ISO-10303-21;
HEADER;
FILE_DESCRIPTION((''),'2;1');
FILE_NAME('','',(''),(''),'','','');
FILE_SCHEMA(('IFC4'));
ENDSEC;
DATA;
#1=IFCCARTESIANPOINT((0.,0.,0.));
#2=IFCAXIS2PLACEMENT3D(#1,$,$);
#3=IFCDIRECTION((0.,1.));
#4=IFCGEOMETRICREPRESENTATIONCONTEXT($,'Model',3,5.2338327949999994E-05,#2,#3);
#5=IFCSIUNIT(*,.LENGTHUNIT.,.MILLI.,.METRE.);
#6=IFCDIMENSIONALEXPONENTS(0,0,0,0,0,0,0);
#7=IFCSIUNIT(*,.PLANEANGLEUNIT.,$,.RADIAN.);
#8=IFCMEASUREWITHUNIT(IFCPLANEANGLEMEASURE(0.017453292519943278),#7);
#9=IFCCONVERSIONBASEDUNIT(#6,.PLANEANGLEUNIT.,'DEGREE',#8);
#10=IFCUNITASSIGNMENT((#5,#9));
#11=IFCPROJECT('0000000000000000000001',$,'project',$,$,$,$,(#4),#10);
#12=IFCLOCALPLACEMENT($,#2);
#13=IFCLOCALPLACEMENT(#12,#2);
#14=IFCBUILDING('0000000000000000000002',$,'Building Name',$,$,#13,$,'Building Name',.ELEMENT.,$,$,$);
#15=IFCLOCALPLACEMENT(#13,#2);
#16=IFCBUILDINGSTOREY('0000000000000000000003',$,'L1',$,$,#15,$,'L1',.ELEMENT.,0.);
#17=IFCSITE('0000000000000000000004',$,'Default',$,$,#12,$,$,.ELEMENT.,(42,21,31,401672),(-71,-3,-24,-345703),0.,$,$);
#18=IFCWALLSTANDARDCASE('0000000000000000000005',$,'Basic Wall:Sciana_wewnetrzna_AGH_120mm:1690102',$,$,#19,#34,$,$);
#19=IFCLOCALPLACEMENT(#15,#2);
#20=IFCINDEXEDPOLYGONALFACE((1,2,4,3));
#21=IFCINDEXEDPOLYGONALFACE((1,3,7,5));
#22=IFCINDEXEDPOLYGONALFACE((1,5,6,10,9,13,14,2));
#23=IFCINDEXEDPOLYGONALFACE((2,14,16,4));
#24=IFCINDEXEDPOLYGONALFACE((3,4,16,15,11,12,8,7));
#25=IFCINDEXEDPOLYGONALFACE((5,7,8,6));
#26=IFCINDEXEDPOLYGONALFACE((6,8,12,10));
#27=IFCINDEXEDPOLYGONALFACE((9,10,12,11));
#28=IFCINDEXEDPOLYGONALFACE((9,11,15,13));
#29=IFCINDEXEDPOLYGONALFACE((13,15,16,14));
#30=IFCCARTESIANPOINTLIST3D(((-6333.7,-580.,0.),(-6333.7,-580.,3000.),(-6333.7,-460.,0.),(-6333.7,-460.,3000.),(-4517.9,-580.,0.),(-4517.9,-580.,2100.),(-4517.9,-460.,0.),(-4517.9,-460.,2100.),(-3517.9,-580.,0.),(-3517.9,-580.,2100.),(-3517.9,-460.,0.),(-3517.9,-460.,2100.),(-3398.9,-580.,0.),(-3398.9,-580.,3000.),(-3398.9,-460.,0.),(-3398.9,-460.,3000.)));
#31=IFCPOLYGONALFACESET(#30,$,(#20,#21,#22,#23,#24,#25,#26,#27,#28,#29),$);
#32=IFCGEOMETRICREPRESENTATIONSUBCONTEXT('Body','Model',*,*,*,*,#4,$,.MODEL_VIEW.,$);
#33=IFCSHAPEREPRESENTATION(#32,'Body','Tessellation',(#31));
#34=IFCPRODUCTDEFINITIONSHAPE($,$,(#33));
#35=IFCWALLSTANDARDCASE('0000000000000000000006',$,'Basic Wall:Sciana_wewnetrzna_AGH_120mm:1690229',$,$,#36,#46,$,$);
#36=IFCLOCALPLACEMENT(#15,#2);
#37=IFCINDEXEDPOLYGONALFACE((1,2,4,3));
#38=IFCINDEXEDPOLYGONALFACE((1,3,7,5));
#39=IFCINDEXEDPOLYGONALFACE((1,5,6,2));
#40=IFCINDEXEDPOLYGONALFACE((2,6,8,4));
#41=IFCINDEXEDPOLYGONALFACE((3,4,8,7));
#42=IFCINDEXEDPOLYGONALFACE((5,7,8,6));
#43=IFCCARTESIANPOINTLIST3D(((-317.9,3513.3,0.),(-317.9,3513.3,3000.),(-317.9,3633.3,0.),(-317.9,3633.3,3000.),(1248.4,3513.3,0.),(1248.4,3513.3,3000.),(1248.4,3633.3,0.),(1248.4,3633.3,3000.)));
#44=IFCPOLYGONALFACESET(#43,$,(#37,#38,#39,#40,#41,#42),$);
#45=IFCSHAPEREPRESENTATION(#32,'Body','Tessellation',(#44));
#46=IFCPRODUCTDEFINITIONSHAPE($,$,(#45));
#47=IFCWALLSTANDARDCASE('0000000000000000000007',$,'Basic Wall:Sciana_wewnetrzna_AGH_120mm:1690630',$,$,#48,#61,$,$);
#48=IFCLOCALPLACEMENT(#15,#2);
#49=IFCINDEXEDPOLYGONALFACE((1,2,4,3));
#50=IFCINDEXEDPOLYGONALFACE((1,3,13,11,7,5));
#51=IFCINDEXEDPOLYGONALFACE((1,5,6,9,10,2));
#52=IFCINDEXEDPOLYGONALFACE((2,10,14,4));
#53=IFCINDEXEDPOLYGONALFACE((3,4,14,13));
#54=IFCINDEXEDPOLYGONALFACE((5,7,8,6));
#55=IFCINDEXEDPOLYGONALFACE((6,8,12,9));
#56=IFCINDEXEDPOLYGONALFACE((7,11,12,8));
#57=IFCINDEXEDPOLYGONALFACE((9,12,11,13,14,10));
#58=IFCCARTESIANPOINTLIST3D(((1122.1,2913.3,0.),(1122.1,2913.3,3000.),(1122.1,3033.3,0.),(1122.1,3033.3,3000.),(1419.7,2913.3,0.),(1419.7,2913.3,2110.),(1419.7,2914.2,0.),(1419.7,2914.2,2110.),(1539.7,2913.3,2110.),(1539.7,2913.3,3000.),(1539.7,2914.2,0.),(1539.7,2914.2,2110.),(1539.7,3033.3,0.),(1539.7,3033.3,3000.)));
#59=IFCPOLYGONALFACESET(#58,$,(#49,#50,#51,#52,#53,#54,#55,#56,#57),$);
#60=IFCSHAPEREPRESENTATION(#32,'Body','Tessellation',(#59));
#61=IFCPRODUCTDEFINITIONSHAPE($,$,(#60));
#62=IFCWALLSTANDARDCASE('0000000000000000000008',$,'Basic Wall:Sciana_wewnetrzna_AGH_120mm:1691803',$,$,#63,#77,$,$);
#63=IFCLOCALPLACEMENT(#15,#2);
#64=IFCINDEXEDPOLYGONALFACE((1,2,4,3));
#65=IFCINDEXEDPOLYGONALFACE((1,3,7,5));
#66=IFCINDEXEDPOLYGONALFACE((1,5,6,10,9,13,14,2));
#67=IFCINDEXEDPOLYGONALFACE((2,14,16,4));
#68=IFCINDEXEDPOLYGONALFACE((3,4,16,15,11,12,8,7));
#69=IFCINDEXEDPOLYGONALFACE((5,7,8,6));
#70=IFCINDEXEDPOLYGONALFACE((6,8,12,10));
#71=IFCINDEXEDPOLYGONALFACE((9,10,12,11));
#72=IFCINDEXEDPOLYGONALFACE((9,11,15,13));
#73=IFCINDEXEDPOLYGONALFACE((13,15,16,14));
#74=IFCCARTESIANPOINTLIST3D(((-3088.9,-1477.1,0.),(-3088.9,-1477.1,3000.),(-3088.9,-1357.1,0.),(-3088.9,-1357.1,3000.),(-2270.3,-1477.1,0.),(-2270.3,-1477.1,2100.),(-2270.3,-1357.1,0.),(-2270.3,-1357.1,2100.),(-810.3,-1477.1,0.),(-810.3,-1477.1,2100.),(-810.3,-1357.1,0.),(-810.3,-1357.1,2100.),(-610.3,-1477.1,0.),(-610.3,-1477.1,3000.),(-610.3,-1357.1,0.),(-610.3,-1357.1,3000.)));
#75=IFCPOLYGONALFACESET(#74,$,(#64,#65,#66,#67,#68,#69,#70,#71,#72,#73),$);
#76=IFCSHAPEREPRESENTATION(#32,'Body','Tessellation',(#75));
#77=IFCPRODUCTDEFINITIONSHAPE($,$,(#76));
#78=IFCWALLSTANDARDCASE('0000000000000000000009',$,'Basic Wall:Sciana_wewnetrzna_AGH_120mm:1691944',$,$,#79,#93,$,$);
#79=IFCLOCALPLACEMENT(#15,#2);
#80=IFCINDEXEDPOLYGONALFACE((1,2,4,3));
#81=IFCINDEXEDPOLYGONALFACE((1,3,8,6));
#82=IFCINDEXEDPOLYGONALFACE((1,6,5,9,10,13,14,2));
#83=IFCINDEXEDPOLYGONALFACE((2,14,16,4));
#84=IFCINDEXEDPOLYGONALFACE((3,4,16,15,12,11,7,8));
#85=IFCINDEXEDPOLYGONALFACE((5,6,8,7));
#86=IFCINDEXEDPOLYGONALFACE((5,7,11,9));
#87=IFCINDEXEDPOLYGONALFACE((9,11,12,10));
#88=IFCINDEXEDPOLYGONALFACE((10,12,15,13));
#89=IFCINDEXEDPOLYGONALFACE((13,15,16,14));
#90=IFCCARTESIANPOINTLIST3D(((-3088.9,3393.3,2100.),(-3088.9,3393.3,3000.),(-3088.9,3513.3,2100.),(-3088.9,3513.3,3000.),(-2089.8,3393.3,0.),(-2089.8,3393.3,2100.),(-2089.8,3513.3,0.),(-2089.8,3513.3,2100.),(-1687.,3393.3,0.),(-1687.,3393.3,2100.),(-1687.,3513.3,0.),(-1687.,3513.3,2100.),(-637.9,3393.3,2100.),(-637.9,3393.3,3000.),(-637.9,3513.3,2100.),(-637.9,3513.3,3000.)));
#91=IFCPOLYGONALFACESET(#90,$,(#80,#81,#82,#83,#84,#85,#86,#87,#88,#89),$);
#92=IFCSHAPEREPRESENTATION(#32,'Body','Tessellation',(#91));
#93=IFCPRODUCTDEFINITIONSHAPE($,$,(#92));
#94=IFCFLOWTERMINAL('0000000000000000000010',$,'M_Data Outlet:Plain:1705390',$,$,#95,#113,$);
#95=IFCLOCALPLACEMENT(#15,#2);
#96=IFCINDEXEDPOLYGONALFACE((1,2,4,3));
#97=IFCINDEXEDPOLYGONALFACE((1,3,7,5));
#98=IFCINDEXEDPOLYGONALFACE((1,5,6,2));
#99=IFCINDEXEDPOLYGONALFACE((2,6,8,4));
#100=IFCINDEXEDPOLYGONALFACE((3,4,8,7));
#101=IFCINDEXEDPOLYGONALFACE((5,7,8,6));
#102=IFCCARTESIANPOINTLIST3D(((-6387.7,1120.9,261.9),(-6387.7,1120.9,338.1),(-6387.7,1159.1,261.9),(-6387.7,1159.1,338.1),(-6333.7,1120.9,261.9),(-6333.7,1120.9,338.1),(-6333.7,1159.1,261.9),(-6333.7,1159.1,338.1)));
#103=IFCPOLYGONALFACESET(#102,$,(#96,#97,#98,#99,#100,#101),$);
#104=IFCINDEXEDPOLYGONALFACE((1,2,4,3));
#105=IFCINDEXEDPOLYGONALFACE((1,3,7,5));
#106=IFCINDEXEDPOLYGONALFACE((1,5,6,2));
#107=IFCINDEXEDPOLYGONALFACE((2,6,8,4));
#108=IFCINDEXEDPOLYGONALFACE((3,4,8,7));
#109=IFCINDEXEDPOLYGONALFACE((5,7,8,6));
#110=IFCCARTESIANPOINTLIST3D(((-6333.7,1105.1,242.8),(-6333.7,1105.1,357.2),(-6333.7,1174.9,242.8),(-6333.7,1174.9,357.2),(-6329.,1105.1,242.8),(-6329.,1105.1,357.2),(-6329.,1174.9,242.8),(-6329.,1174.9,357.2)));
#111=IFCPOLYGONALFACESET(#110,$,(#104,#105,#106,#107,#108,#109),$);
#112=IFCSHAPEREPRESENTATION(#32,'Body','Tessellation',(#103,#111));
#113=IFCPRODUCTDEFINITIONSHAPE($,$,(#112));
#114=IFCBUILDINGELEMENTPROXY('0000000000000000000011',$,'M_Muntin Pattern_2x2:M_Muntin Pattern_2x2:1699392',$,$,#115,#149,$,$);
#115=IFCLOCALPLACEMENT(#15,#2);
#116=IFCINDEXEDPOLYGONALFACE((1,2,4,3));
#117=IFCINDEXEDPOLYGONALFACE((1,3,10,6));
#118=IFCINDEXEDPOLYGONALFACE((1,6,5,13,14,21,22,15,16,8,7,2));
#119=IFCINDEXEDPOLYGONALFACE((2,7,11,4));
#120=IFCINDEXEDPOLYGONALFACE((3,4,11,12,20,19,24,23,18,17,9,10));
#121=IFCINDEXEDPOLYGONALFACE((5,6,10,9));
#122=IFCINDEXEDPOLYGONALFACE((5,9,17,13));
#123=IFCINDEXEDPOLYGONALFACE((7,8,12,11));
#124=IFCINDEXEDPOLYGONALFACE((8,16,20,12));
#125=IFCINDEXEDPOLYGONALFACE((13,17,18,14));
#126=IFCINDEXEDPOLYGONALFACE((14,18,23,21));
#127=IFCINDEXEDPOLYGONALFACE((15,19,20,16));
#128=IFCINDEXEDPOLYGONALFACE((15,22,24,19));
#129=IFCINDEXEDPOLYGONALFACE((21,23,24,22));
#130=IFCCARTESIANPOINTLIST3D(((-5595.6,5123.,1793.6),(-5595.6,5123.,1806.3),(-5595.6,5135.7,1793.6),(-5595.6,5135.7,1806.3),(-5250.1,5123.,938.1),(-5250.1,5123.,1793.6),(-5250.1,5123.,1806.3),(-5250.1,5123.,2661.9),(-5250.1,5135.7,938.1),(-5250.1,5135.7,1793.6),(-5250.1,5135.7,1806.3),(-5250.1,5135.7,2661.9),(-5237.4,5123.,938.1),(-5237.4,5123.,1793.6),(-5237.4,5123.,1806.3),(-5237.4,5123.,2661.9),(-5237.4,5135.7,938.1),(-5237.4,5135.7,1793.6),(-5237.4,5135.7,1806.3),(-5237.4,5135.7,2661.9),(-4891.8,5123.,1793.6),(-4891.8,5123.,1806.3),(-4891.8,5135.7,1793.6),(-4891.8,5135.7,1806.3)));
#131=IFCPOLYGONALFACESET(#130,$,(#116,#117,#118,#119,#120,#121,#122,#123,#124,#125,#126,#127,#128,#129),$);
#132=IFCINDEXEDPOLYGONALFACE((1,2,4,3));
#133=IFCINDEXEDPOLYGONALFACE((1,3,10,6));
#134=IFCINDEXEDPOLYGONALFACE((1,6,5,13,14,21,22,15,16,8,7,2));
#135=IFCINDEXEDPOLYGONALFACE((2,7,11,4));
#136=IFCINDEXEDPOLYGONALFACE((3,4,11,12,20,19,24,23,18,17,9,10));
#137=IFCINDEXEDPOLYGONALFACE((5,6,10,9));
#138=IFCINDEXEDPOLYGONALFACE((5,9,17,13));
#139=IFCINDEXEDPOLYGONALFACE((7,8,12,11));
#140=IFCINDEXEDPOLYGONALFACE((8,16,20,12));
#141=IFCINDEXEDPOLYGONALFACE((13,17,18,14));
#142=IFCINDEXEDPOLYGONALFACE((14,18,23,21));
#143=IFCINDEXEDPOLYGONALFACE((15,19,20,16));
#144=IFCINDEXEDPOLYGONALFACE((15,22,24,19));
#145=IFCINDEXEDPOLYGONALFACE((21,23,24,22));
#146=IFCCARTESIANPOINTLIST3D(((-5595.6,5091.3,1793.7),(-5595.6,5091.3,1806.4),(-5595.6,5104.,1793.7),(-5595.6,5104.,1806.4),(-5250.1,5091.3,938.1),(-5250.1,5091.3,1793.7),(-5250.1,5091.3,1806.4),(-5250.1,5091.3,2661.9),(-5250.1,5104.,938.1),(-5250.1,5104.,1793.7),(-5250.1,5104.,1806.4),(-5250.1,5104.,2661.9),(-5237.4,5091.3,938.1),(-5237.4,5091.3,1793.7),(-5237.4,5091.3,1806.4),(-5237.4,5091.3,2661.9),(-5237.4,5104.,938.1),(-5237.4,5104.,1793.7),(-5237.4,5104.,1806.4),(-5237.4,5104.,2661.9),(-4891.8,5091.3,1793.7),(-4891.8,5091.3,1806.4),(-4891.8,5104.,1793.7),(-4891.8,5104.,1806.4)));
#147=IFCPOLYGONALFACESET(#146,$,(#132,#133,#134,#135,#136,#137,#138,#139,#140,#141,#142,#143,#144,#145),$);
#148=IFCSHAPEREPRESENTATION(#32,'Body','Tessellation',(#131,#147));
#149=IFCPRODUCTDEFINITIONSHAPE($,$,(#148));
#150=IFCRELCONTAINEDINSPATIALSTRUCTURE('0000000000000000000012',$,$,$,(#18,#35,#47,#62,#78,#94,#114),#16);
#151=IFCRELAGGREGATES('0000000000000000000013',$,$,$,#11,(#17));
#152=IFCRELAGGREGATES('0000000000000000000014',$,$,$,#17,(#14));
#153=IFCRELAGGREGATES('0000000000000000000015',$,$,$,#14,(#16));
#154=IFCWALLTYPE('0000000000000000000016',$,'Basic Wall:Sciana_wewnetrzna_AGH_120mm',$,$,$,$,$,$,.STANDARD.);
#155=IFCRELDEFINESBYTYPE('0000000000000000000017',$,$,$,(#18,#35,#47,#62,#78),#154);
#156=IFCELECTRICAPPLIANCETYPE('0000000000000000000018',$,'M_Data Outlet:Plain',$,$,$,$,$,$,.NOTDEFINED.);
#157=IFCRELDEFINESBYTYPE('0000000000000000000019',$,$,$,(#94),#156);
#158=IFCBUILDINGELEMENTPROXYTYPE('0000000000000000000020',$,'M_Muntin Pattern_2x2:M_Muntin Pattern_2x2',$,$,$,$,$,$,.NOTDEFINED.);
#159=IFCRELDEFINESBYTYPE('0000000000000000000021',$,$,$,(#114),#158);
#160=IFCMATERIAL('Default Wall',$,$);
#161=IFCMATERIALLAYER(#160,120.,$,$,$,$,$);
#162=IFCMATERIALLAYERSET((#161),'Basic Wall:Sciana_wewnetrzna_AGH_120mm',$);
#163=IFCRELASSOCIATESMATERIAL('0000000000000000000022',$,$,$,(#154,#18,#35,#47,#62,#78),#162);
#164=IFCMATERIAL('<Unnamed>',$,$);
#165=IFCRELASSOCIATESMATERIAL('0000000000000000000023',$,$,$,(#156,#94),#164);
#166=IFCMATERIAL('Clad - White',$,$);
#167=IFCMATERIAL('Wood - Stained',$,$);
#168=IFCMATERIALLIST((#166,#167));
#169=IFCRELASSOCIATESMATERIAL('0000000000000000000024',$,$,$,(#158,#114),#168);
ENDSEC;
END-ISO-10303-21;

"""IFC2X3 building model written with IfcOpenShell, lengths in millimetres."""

from ifc_helpers import new_model, entity, si_unit, converted_unit, direction, frame, frame_2d, origin, place, context, subcontext, project, spatial, polyline, rectangle, outline, extrude, source, transform, mapped, material, material_list, layer, layer_set, layer_usage, type_object, type_shapes, element, save


model = new_model("IFC2X3")

# Units and contexts
model_context = context("Model", 3, precision=5.2338327949999994e-05, world=origin(), true_north=direction((0.0, 1.0)))
body_context = subcontext(model_context, "Body", "Model", "MODEL_VIEW")
ifc_project = project(units=[si_unit("LENGTHUNIT", "METRE", prefix="MILLI"), converted_unit("PLANEANGLEUNIT", "DEGREE", entity("IfcPlaneAngleMeasure", 0.017453292519943278), si_unit("PLANEANGLEUNIT", "RADIAN"), dimensions=[0, 0, 0, 0, 0, 0, 0])], contexts=[model_context])

# Site, building, storey
site_placement = place(None, origin())
site = spatial("IfcSite", under=ifc_project, at=site_placement, Name="Default", CompositionType="ELEMENT", RefLatitude=(42, 21, 31, 401672), RefLongitude=(-71, -3, -24, -345703), RefElevation=0.0)
building_placement = place(site_placement, origin())
building = spatial("IfcBuilding", under=site, at=building_placement, Name="Building Name", LongName="Building Name", CompositionType="ELEMENT")
storey_placement = place(building_placement, origin())
storey = spatial("IfcBuildingStorey", under=building, at=storey_placement, Name="L1", LongName="L1", CompositionType="ELEMENT", Elevation=0.0)

# Shared definitions
ifc_material_1 = material(Name="Default Wall")

# Wall, opening
ifc_layer_1 = layer(ifc_material_1, 120.0)
ifc_layer_set_1 = layer_set([ifc_layer_1], Name="Basic Wall:Sciana_wewnetrzna_AGH_120mm")
ifc_layer_usage_1 = layer_usage(ifc_layer_set_1, "AXIS2", "NEGATIVE", 60.0)
wall_type_1 = type_object("IfcWallType", Name="Basic Wall:Sciana_wewnetrzna_AGH_120mm", PredefinedType="STANDARD", material=ifc_layer_set_1)
wall_1_placement = place(storey_placement, frame((-6333.7, -520.0, 0.0)))
wall_1 = element("IfcWallStandardCase", 1, at=wall_1_placement, inside=storey, type_object=wall_type_1, material=ifc_layer_usage_1, Name="Basic Wall:Sciana_wewnetrzna_AGH_120mm:1690102", context=body_context, shape_type="SweptSolid", body=[
    extrude(rectangle(XDim=2934.8, YDim=120.0, at=frame_2d((1467.4, 0.0), x_axis=(1.0, 0.0))), origin(), (0.0, 0.0, 1.0), 3000.0),
])
opening_1_placement = place(wall_1_placement, frame((1815.8, -60.0, 0.0)))
element("IfcOpeningElement", 2, at=opening_1_placement, cuts=wall_1, ObjectType="Opening", context=body_context, shape_type="SweptSolid", body=[
    extrude(rectangle(XDim=2100.0, YDim=1000.0, at=frame_2d((1050.0, 500.0), x_axis=(1.0, 0.0))), frame((0.0, 0.0, 0.0), z_axis=(0.0, 1.0, 0.0), x_axis=(0.0, 0.0, 1.0)), (0.0, 0.0, 1.0), 120.0),
])

# Wall
ifc_layer_usage_2 = layer_usage(ifc_layer_set_1, "AXIS2", "NEGATIVE", 60.0)
wall_2_placement = place(storey_placement, frame((-317.9, 3573.3, 0.0)))
element("IfcWallStandardCase", 3, at=wall_2_placement, inside=storey, type_object=wall_type_1, material=ifc_layer_usage_2, Name="Basic Wall:Sciana_wewnetrzna_AGH_120mm:1690229", context=body_context, shape_type="SweptSolid", body=[
    extrude(rectangle(XDim=1566.4, YDim=120.0, at=frame_2d((783.2, 0.0), x_axis=(-1.0, 0.0))), origin(), (0.0, 0.0, 1.0), 3000.0),
])

# Walls, openings
ifc_layer_usage_3 = layer_usage(ifc_layer_set_1, "AXIS2", "NEGATIVE", 60.0)
wall_3_placement = place(storey_placement, frame((1122.1, 2973.3, 0.0)))
wall_3 = element("IfcWallStandardCase", 4, at=wall_3_placement, inside=storey, type_object=wall_type_1, material=ifc_layer_usage_3, Name="Basic Wall:Sciana_wewnetrzna_AGH_120mm:1690630", context=body_context, shape_type="SweptSolid", body=[
    extrude(rectangle(XDim=417.6, YDim=120.0, at=frame_2d((208.8, 0.0), x_axis=(-1.0, 0.0))), origin(), (0.0, 0.0, 1.0), 3000.0),
])
opening_2_placement = place(wall_3_placement, origin())
element("IfcOpeningElement", 5, at=opening_2_placement, cuts=wall_3, ObjectType="Opening", context=body_context, shape_type="SweptSolid", body=[
    extrude(rectangle(XDim=2110.0, YDim=120.0, at=frame_2d((0.0, 0.0), x_axis=(0.0, 1.0))), frame((357.6, -1059.1, 1055.0), z_axis=(0.0, 1.0, 0.0), x_axis=(-1.0, 0.0, 0.0)), (0.0, 0.0, 1.0), 1000.0),
])
ifc_layer_usage_4 = layer_usage(ifc_layer_set_1, "AXIS2", "NEGATIVE", 60.0)
wall_4_placement = place(storey_placement, frame((-3088.9, -1417.1, 0.0)))
wall_4 = element("IfcWallStandardCase", 6, at=wall_4_placement, inside=storey, type_object=wall_type_1, material=ifc_layer_usage_4, Name="Basic Wall:Sciana_wewnetrzna_AGH_120mm:1691803", context=body_context, shape_type="SweptSolid", body=[
    extrude(rectangle(XDim=2478.6, YDim=120.0, at=frame_2d((1239.3, 0.0), x_axis=(1.0, 0.0))), origin(), (0.0, 0.0, 1.0), 3000.0),
])
opening_3_placement = place(wall_4_placement, frame((818.6, -60.0, 0.0)))
element("IfcOpeningElement", 7, at=opening_3_placement, cuts=wall_4, ObjectType="Opening", context=body_context, shape_type="SweptSolid", body=[
    extrude(rectangle(XDim=2100.0, YDim=1460.0, at=frame_2d((1050.0, 730.0), x_axis=(1.0, 0.0))), frame((0.0, 0.0, 0.0), z_axis=(0.0, 1.0, 0.0), x_axis=(0.0, 0.0, 1.0)), (0.0, 0.0, 1.0), 120.0),
])

# Wall, openings
ifc_layer_usage_5 = layer_usage(ifc_layer_set_1, "AXIS2", "NEGATIVE", 60.0)
wall_5_placement = place(storey_placement, frame((-3088.9, 3453.3, 0.0)))
wall_5 = element("IfcWallStandardCase", 8, at=wall_5_placement, inside=storey, type_object=wall_type_1, material=ifc_layer_usage_5, Name="Basic Wall:Sciana_wewnetrzna_AGH_120mm:1691944", context=body_context, shape_type="SweptSolid", body=[
    extrude(rectangle(XDim=2451.0, YDim=120.0, at=frame_2d((1225.5, 0.0), x_axis=(-1.0, 0.0))), origin(), (0.0, 0.0, 1.0), 3000.0),
])
opening_4_placement = place(wall_5_placement, frame((-0.9, -60.0, 0.0)))
element("IfcOpeningElement", 9, at=opening_4_placement, cuts=wall_5, ObjectType="Opening", context=body_context, shape_type="SweptSolid", body=[
    extrude(rectangle(XDim=2100.0, YDim=1000.0, at=frame_2d((1050.0, 500.0), x_axis=(1.0, 0.0))), frame((0.0, 0.0, 0.0), z_axis=(0.0, 1.0, 0.0), x_axis=(0.0, 0.0, 1.0)), (0.0, 0.0, 1.0), 120.0),
])
opening_5_placement = place(wall_5_placement, frame((1401.9, -60.0, 0.0)))
element("IfcOpeningElement", 10, at=opening_5_placement, cuts=wall_5, ObjectType="Opening", context=body_context, shape_type="SweptSolid", body=[
    extrude(rectangle(XDim=2100.0, YDim=1100.0, at=frame_2d((1050.0, 550.0), x_axis=(1.0, 0.0))), frame((0.0, 0.0, 0.0), z_axis=(0.0, 1.0, 0.0), x_axis=(0.0, 0.0, 1.0)), (0.0, 0.0, 1.0), 120.0),
])

# Flow terminal
ifc_material_2 = material(Name="<Unnamed>")
electric_appliance_type = type_object("IfcElectricApplianceType", Name="M_Data Outlet:Plain", PredefinedType="NOTDEFINED", material=ifc_material_2)
shared_shape_1 = source(origin(), body_context, "Body", "SweptSolid", [
    extrude(rectangle(XDim=38.1, YDim=76.2, at=frame_2d((0.0, 0.0), x_axis=(1.0, 0.0))), frame((0.0, 0.0, -54.0), z_axis=(0.0, 0.0, 1.0), x_axis=(-1.0, 0.0, 0.0)), (0.0, 0.0, 1.0), 54.0),
    extrude(rectangle(XDim=69.9, YDim=114.3, at=frame_2d((0.0, 0.0), x_axis=(1.0, 0.0))), frame((0.0, 0.0, 0.0), z_axis=(0.0, 0.0, 1.0), x_axis=(-1.0, 0.0, 0.0)), (0.0, 0.0, 1.0), 4.8),
])
type_shapes(electric_appliance_type, [shared_shape_1])
flow_terminal_placement = place(storey_placement, frame((-6333.7, 1140.0, 300.0), z_axis=(1.0, 0.0, 0.0), x_axis=(0.0, 1.0, 0.0)))
element("IfcFlowTerminal", 11, at=flow_terminal_placement, inside=storey, type_object=electric_appliance_type, material=ifc_material_2, Name="M_Data Outlet:Plain:1705390", context=body_context, shape_type="MappedRepresentation", body=[
    mapped(shared_shape_1, transform((0.0, 0.0, 0.0), scale=1.0)),
])

# Building element proxy
ifc_material_3 = material(Name="Clad - White")
ifc_material_4 = material(Name="Wood - Stained")
ifc_material_list = material_list([ifc_material_3, ifc_material_4])
building_element_proxy_type_1 = type_object("IfcBuildingElementProxyType", Name="M_Muntin Pattern_2x2:M_Muntin Pattern_2x2", PredefinedType="NOTDEFINED", material=ifc_material_list)
shared_shape_2 = source(origin(), body_context, "Body", "SweptSolid", [
    extrude(outline(polyline([(6.4, -6.4), (861.9, -6.4), (861.9, 6.3), (6.4, 6.3), (6.4, 351.9), (-6.3, 351.9), (-6.3, 6.3), (-861.9, 6.3), (-861.9, -6.4), (-6.3, -6.4), (-6.3, -351.9), (6.4, -351.9), (6.4, -6.4)])), frame((0.0, 9.5, 861.9), z_axis=(0.0, 1.0, 0.0), x_axis=(0.0, 0.0, 1.0)), (0.0, 0.0, 1.0), 12.7),
    extrude(outline(polyline([(6.4, -6.4), (861.9, -6.4), (861.9, 6.3), (6.4, 6.3), (6.4, 351.9), (-6.3, 351.9), (-6.3, 6.3), (-861.9, 6.3), (-861.9, -6.4), (-6.3, -6.4), (-6.3, -351.9), (6.4, -351.9), (6.4, -6.4)])), frame((0.0, -22.2, 861.9), z_axis=(0.0, 1.0, 0.0), x_axis=(0.0, 0.0, 1.0)), (0.0, 0.0, 1.0), 12.7),
])
type_shapes(building_element_proxy_type_1, [shared_shape_2])
proxy_1_placement = place(storey_placement, frame((-5243.7, 5113.5, 938.1)))
element("IfcBuildingElementProxy", 12, at=proxy_1_placement, inside=storey, type_object=building_element_proxy_type_1, material=ifc_material_list, Name="M_Muntin Pattern_2x2:M_Muntin Pattern_2x2:1699392", context=body_context, shape_type="MappedRepresentation", body=[
    mapped(shared_shape_2, transform((0.0, 0.0, 0.0), scale=1.0)),
])

save(model, "model.ifc")
